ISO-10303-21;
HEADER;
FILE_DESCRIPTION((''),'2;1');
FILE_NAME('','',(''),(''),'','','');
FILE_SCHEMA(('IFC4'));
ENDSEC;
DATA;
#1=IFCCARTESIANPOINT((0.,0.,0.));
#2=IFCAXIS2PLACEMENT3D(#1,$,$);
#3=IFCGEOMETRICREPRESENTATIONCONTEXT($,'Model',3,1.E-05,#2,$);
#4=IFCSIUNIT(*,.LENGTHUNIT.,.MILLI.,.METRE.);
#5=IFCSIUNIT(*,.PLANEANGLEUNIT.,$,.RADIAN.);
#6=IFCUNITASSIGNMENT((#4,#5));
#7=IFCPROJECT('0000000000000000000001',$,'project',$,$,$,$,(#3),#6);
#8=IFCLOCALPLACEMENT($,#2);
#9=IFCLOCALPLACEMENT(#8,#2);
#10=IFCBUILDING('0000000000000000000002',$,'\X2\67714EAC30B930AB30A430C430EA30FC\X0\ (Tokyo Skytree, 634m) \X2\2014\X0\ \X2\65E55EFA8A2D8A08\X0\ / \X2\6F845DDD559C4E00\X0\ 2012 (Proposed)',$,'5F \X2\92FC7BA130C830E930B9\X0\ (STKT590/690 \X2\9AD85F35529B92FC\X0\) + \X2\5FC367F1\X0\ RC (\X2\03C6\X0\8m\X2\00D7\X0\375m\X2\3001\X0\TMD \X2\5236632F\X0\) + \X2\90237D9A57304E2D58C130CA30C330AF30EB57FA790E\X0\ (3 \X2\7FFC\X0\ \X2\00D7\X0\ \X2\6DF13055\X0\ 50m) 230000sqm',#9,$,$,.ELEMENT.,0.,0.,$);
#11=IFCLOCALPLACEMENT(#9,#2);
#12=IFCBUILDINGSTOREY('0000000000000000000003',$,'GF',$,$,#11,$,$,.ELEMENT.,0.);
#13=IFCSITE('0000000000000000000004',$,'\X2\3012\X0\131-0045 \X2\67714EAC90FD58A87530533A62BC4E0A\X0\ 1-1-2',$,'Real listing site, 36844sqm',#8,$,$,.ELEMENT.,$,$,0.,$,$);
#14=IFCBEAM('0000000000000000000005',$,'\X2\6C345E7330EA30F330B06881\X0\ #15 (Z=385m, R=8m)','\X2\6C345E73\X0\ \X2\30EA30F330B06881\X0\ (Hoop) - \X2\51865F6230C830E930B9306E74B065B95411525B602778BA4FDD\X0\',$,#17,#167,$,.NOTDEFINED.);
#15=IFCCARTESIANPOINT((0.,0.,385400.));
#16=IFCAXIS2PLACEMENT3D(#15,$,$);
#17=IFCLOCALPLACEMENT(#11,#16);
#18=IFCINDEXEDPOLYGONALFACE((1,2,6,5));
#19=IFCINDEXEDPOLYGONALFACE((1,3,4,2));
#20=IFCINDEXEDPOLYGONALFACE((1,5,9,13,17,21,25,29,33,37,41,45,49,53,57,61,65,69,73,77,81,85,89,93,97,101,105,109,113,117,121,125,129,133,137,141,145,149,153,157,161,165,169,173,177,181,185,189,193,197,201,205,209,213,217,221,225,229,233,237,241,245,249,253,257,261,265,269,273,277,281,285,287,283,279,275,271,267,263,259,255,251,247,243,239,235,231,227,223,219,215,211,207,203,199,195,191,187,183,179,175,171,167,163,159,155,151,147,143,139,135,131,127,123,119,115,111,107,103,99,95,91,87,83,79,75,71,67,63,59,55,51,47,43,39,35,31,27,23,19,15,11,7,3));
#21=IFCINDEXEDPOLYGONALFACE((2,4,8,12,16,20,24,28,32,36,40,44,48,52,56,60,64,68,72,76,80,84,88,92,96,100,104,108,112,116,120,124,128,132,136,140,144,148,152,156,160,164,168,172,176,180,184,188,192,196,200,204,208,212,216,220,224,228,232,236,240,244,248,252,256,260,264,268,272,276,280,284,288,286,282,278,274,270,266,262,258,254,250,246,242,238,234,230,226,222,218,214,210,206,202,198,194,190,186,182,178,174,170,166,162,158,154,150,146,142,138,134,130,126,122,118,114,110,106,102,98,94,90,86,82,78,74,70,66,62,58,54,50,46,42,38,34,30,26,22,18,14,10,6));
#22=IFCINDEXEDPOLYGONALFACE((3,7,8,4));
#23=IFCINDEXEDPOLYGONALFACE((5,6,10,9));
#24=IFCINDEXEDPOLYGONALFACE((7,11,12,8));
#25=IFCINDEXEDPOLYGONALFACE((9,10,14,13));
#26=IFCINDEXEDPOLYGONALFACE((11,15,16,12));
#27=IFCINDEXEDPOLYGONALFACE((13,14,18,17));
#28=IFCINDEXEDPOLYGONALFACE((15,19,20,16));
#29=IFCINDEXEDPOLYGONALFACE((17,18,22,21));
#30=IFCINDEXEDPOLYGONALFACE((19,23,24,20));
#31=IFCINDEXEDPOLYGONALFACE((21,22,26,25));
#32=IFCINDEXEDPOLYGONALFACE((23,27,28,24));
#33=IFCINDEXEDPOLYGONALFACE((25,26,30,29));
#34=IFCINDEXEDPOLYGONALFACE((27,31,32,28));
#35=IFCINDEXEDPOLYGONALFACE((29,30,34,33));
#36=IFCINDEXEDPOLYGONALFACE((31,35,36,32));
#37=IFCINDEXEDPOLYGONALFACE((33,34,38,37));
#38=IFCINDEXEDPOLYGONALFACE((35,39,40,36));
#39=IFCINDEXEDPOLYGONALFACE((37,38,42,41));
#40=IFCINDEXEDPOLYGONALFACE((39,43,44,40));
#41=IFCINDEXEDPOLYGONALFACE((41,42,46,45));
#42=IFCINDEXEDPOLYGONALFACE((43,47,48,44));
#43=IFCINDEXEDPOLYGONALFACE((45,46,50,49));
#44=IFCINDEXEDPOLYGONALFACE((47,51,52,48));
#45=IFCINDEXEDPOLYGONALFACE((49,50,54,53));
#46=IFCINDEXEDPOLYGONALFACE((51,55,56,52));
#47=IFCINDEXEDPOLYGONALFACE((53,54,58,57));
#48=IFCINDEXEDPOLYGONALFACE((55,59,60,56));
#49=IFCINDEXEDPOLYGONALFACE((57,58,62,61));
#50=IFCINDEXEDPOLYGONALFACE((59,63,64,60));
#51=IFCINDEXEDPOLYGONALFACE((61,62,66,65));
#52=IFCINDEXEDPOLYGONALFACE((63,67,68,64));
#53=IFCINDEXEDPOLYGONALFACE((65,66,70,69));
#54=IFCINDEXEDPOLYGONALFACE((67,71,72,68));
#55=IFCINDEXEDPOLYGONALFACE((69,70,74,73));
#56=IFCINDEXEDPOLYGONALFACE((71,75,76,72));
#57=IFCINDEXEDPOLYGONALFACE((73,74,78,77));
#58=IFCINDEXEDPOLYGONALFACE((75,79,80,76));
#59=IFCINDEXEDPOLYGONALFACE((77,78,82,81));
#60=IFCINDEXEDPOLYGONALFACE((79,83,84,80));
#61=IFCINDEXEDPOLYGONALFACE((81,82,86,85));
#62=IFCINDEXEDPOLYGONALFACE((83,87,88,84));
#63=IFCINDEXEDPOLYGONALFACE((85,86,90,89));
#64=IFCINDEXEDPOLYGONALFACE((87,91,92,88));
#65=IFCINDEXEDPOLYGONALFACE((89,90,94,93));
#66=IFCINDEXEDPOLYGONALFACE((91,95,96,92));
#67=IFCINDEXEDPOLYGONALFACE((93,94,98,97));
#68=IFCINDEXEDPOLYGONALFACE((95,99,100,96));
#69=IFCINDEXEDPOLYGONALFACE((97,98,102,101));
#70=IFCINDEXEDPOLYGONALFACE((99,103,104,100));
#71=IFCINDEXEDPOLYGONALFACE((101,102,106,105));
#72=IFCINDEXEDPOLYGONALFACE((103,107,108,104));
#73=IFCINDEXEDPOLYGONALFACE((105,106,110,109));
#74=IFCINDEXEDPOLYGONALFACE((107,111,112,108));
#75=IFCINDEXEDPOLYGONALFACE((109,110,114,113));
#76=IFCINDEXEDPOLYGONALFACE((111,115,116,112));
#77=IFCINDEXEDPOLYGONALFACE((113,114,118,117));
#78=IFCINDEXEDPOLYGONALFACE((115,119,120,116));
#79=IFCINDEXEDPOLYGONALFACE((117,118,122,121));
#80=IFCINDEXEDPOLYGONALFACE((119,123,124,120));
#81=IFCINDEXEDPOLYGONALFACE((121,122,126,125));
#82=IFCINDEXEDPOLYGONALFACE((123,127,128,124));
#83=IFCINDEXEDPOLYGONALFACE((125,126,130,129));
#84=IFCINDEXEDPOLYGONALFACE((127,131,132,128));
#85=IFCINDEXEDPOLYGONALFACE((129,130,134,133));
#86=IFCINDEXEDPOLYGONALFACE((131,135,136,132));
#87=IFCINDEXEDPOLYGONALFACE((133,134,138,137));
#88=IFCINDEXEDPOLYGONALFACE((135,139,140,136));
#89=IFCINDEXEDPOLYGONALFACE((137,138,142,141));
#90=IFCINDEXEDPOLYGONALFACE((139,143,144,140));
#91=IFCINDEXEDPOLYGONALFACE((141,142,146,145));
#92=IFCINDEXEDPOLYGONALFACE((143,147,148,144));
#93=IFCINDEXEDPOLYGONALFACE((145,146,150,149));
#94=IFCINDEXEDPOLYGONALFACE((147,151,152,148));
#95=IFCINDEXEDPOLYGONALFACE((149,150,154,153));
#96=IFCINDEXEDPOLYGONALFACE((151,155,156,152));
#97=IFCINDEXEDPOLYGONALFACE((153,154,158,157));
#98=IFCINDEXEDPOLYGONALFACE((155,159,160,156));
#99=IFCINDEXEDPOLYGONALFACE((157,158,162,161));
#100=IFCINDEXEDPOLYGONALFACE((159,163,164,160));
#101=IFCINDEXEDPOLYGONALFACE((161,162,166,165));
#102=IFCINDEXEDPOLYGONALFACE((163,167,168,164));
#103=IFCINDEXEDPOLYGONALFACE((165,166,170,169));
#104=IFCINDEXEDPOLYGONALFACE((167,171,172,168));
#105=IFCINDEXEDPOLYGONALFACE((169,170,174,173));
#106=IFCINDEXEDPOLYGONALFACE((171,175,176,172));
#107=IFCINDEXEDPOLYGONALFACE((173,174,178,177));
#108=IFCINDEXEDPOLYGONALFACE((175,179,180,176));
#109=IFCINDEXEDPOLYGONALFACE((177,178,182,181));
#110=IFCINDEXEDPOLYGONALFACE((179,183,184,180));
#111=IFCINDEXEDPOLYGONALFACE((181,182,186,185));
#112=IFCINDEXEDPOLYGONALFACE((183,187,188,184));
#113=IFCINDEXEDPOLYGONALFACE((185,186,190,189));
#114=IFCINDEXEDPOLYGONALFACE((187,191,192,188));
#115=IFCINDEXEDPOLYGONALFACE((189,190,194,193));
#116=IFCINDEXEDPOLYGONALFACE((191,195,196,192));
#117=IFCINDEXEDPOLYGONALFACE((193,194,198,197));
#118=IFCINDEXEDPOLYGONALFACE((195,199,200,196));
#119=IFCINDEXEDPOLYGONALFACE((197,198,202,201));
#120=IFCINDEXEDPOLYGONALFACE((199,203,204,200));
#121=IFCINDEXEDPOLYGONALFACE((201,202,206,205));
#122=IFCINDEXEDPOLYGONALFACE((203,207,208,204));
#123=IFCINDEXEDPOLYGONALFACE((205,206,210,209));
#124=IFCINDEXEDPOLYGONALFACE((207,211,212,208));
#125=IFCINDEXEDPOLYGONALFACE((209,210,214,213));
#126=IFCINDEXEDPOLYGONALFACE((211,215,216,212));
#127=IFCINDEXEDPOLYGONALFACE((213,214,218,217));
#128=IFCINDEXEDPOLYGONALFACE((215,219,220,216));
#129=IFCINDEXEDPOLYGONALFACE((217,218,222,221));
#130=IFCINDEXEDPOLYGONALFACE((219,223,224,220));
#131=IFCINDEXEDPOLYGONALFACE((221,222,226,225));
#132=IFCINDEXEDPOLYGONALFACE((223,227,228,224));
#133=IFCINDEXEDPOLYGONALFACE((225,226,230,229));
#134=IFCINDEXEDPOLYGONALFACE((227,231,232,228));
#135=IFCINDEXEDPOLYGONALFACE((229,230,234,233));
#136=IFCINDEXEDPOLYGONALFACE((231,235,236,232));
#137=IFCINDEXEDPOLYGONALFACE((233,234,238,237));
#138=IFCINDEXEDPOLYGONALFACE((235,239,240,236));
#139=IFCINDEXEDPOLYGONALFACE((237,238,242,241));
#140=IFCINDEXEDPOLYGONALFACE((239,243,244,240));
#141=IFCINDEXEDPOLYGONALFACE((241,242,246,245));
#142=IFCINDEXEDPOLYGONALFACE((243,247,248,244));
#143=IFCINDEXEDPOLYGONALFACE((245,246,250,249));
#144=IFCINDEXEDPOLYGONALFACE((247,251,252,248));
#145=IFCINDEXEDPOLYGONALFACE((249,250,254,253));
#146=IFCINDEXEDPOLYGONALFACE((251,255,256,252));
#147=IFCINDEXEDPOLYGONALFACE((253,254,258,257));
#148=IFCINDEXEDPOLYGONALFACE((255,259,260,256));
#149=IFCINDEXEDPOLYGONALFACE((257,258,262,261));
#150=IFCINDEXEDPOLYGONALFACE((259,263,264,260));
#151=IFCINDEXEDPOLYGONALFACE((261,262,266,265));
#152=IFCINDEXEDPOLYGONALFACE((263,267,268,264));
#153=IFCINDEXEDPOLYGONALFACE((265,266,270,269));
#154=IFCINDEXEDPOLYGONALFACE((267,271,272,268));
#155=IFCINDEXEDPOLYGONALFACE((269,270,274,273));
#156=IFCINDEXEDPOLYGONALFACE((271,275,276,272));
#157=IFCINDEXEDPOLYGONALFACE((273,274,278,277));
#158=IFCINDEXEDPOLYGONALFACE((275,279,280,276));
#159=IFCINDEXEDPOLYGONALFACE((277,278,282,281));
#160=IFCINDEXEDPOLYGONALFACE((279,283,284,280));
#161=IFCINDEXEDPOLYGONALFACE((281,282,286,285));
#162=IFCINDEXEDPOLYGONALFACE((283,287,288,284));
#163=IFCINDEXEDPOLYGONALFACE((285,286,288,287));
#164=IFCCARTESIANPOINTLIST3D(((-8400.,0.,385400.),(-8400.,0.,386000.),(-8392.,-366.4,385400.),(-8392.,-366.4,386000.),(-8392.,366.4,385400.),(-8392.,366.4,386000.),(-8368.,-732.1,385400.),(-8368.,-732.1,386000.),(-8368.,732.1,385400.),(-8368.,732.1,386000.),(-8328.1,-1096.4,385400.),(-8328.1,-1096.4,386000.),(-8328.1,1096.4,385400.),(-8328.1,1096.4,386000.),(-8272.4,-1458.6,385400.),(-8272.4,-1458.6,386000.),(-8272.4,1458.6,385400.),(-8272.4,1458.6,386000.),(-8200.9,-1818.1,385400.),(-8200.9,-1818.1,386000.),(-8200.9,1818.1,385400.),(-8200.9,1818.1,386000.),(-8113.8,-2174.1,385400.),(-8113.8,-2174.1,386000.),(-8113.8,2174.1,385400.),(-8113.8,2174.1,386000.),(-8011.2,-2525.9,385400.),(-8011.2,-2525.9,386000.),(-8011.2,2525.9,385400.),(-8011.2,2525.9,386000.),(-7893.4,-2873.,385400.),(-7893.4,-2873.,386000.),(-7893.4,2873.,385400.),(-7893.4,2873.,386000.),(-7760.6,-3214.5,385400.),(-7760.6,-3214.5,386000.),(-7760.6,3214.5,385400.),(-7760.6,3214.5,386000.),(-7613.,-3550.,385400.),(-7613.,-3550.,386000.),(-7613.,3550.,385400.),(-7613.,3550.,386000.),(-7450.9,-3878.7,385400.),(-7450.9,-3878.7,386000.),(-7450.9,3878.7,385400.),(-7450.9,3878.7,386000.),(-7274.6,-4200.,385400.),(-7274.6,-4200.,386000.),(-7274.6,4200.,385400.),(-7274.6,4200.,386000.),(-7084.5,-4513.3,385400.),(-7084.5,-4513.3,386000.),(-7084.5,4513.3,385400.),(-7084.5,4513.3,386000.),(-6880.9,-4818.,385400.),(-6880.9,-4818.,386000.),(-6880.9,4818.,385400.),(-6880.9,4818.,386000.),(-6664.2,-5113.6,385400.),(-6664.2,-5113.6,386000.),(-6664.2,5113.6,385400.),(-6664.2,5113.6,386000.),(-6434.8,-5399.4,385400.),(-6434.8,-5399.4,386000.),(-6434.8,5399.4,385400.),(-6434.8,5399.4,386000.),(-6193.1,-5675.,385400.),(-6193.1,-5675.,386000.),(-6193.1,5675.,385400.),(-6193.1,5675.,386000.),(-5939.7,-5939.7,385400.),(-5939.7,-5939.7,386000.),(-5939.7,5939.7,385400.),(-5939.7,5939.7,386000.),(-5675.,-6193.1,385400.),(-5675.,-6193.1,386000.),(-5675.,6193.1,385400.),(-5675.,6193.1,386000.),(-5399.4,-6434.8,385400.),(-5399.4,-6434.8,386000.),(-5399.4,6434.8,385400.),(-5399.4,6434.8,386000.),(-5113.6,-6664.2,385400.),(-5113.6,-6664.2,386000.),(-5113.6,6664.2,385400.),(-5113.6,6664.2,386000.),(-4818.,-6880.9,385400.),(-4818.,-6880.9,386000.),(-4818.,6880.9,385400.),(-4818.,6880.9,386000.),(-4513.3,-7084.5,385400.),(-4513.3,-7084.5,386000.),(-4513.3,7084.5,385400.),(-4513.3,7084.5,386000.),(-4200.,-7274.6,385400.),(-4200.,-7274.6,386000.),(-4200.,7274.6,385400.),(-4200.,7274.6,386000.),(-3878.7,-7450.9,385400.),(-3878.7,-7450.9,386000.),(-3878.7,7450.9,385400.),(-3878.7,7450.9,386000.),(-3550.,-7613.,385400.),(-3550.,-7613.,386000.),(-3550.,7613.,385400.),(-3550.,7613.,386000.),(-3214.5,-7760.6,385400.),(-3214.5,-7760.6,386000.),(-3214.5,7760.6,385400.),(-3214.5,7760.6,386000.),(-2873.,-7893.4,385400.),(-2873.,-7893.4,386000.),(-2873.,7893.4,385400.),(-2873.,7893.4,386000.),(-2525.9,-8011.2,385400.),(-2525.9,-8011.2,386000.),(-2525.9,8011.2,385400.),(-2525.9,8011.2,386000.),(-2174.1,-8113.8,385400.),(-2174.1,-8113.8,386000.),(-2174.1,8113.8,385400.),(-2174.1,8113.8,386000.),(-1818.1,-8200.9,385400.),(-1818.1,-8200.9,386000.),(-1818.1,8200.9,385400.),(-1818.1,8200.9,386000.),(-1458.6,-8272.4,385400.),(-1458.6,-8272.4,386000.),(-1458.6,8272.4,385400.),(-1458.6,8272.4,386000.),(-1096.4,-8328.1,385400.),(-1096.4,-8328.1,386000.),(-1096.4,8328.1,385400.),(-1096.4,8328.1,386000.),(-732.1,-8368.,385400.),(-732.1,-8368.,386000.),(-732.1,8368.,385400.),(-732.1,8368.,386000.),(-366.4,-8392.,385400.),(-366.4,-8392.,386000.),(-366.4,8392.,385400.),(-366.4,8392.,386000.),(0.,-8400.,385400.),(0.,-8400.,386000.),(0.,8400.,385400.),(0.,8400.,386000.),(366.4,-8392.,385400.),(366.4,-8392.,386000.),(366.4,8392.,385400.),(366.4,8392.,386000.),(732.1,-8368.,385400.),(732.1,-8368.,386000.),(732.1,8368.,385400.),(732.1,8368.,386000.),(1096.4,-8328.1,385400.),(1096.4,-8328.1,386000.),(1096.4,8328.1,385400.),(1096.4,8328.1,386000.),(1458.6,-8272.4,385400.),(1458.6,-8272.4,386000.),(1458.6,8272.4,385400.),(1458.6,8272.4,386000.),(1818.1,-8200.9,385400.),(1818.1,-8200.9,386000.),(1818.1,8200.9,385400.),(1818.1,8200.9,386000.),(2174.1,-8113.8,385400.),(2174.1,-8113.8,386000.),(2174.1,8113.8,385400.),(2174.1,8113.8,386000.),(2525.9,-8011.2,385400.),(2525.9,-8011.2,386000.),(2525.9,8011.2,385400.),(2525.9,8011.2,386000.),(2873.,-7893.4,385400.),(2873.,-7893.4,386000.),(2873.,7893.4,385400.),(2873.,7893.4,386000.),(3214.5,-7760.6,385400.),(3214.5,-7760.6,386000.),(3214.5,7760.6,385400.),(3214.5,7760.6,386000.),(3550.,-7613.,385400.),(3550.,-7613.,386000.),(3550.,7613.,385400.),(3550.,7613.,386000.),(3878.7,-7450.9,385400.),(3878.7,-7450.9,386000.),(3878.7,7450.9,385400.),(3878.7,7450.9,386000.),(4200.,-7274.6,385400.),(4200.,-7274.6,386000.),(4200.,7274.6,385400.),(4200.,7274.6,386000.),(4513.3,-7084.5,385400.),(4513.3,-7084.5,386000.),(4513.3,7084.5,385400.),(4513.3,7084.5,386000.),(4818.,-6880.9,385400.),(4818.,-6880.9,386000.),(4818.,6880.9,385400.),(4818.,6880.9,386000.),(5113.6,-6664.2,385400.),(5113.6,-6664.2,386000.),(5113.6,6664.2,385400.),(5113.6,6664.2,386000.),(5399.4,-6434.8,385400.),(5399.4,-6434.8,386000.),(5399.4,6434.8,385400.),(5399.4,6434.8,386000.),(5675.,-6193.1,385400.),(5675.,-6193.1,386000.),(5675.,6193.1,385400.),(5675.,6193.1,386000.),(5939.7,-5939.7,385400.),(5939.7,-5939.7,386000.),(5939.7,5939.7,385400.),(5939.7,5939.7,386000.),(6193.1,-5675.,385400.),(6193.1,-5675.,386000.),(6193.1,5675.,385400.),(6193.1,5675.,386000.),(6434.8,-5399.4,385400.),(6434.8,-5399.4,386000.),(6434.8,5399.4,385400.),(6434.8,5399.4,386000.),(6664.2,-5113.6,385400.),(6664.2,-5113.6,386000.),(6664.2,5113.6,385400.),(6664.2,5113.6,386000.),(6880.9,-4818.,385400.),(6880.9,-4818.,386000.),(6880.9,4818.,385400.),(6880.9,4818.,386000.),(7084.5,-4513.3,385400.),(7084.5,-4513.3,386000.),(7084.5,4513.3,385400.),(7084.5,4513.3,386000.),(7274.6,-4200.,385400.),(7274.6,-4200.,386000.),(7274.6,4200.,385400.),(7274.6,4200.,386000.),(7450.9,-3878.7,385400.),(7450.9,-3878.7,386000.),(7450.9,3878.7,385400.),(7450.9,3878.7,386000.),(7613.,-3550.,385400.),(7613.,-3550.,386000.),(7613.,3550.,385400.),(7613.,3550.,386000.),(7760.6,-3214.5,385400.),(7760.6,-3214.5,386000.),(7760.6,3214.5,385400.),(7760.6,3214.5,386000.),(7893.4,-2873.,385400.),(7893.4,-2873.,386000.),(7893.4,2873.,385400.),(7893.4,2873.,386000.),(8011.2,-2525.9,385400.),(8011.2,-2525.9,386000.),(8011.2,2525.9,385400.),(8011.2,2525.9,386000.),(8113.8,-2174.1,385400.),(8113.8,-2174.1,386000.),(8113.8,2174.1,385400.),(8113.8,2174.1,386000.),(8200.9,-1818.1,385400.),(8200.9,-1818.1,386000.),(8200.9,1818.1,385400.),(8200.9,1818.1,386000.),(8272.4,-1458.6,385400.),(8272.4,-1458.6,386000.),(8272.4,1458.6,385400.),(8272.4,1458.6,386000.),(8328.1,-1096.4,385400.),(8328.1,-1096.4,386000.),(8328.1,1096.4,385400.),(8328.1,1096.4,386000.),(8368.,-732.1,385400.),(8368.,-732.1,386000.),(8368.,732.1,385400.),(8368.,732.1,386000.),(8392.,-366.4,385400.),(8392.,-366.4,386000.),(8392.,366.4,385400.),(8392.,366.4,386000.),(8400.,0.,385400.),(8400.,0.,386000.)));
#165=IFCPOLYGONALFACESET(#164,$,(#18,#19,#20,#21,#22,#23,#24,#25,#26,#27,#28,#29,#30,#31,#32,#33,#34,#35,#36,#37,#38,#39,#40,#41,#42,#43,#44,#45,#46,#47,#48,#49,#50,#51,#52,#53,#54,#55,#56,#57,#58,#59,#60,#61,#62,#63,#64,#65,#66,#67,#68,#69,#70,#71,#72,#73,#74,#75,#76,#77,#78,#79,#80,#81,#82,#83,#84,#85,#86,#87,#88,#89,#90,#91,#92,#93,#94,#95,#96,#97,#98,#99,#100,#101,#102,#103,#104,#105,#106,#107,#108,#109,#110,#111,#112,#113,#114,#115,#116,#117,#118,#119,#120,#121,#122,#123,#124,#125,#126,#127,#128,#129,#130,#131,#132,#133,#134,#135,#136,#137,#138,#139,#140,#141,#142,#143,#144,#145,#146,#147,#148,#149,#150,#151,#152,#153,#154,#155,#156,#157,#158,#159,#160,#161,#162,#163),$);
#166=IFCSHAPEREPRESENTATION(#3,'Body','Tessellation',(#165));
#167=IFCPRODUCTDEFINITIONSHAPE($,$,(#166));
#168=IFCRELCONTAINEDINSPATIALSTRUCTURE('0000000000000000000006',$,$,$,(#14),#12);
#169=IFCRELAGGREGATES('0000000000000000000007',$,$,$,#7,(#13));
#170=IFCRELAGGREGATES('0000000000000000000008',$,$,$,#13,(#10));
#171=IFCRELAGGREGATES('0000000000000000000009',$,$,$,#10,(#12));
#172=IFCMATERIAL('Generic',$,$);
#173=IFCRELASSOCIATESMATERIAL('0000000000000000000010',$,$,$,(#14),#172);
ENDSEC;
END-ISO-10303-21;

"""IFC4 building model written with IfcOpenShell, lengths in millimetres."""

from ifc_helpers import new_model, si_unit, frame, origin, origin_2d, place, context, project, spatial, circle, extrude, material, element, save


model = new_model("IFC4")

# Units and contexts
model_context = context("Model", 3, precision=1e-05, world=origin())
ifc_project = project(units=[si_unit("LENGTHUNIT", "METRE", prefix="MILLI"), si_unit("PLANEANGLEUNIT", "RADIAN")], contexts=[model_context])

# Site, building, storey
site_placement = place(None, origin())
site = spatial("IfcSite", under=ifc_project, at=site_placement, Name="〒131-0045 東京都墨田区押上 1-1-2", ObjectType="Real listing site, 36844sqm", CompositionType="ELEMENT", RefElevation=0.0)
building_placement = place(site_placement, origin())
building = spatial("IfcBuilding", under=site, at=building_placement, Name="東京スカイツリー (Tokyo Skytree, 634m) — 日建設計 / 澄川喜一 2012 (Proposed)", ObjectType="5F 鋼管トラス (STKT590/690 高張力鋼) + 心柱 RC (φ8m×375m、TMD 制振) + 連続地中壁ナックル基礎 (3 翼 × 深さ 50m) 230000sqm", CompositionType="ELEMENT", ElevationOfRefHeight=0.0, ElevationOfTerrain=0.0)
storey_placement = place(building_placement, origin())
storey = spatial("IfcBuildingStorey", under=building, at=storey_placement, Name="GF", CompositionType="ELEMENT", Elevation=0.0)

# Shared definitions
ifc_material_1 = material(Name="Generic")

# Beam
beam_1_placement = place(storey_placement, frame((0.0, 0.0, 385400.0)))
element("IfcBeam", 1, at=beam_1_placement, inside=storey, material=ifc_material_1, Name="水平リング梁 #15 (Z=385m, R=8m)", Description="水平 リング梁 (Hoop) - 円形トラスの環方向剛性確保", PredefinedType="NOTDEFINED", context=model_context, shape_type="SweptSolid", body=[
    extrude(circle(Radius=8400.0, at=origin_2d()), frame((0.0, 0.0, 385400.0)), (0.0, 0.0, 1.0), 600.0),
])

save(model, "model.ifc")
